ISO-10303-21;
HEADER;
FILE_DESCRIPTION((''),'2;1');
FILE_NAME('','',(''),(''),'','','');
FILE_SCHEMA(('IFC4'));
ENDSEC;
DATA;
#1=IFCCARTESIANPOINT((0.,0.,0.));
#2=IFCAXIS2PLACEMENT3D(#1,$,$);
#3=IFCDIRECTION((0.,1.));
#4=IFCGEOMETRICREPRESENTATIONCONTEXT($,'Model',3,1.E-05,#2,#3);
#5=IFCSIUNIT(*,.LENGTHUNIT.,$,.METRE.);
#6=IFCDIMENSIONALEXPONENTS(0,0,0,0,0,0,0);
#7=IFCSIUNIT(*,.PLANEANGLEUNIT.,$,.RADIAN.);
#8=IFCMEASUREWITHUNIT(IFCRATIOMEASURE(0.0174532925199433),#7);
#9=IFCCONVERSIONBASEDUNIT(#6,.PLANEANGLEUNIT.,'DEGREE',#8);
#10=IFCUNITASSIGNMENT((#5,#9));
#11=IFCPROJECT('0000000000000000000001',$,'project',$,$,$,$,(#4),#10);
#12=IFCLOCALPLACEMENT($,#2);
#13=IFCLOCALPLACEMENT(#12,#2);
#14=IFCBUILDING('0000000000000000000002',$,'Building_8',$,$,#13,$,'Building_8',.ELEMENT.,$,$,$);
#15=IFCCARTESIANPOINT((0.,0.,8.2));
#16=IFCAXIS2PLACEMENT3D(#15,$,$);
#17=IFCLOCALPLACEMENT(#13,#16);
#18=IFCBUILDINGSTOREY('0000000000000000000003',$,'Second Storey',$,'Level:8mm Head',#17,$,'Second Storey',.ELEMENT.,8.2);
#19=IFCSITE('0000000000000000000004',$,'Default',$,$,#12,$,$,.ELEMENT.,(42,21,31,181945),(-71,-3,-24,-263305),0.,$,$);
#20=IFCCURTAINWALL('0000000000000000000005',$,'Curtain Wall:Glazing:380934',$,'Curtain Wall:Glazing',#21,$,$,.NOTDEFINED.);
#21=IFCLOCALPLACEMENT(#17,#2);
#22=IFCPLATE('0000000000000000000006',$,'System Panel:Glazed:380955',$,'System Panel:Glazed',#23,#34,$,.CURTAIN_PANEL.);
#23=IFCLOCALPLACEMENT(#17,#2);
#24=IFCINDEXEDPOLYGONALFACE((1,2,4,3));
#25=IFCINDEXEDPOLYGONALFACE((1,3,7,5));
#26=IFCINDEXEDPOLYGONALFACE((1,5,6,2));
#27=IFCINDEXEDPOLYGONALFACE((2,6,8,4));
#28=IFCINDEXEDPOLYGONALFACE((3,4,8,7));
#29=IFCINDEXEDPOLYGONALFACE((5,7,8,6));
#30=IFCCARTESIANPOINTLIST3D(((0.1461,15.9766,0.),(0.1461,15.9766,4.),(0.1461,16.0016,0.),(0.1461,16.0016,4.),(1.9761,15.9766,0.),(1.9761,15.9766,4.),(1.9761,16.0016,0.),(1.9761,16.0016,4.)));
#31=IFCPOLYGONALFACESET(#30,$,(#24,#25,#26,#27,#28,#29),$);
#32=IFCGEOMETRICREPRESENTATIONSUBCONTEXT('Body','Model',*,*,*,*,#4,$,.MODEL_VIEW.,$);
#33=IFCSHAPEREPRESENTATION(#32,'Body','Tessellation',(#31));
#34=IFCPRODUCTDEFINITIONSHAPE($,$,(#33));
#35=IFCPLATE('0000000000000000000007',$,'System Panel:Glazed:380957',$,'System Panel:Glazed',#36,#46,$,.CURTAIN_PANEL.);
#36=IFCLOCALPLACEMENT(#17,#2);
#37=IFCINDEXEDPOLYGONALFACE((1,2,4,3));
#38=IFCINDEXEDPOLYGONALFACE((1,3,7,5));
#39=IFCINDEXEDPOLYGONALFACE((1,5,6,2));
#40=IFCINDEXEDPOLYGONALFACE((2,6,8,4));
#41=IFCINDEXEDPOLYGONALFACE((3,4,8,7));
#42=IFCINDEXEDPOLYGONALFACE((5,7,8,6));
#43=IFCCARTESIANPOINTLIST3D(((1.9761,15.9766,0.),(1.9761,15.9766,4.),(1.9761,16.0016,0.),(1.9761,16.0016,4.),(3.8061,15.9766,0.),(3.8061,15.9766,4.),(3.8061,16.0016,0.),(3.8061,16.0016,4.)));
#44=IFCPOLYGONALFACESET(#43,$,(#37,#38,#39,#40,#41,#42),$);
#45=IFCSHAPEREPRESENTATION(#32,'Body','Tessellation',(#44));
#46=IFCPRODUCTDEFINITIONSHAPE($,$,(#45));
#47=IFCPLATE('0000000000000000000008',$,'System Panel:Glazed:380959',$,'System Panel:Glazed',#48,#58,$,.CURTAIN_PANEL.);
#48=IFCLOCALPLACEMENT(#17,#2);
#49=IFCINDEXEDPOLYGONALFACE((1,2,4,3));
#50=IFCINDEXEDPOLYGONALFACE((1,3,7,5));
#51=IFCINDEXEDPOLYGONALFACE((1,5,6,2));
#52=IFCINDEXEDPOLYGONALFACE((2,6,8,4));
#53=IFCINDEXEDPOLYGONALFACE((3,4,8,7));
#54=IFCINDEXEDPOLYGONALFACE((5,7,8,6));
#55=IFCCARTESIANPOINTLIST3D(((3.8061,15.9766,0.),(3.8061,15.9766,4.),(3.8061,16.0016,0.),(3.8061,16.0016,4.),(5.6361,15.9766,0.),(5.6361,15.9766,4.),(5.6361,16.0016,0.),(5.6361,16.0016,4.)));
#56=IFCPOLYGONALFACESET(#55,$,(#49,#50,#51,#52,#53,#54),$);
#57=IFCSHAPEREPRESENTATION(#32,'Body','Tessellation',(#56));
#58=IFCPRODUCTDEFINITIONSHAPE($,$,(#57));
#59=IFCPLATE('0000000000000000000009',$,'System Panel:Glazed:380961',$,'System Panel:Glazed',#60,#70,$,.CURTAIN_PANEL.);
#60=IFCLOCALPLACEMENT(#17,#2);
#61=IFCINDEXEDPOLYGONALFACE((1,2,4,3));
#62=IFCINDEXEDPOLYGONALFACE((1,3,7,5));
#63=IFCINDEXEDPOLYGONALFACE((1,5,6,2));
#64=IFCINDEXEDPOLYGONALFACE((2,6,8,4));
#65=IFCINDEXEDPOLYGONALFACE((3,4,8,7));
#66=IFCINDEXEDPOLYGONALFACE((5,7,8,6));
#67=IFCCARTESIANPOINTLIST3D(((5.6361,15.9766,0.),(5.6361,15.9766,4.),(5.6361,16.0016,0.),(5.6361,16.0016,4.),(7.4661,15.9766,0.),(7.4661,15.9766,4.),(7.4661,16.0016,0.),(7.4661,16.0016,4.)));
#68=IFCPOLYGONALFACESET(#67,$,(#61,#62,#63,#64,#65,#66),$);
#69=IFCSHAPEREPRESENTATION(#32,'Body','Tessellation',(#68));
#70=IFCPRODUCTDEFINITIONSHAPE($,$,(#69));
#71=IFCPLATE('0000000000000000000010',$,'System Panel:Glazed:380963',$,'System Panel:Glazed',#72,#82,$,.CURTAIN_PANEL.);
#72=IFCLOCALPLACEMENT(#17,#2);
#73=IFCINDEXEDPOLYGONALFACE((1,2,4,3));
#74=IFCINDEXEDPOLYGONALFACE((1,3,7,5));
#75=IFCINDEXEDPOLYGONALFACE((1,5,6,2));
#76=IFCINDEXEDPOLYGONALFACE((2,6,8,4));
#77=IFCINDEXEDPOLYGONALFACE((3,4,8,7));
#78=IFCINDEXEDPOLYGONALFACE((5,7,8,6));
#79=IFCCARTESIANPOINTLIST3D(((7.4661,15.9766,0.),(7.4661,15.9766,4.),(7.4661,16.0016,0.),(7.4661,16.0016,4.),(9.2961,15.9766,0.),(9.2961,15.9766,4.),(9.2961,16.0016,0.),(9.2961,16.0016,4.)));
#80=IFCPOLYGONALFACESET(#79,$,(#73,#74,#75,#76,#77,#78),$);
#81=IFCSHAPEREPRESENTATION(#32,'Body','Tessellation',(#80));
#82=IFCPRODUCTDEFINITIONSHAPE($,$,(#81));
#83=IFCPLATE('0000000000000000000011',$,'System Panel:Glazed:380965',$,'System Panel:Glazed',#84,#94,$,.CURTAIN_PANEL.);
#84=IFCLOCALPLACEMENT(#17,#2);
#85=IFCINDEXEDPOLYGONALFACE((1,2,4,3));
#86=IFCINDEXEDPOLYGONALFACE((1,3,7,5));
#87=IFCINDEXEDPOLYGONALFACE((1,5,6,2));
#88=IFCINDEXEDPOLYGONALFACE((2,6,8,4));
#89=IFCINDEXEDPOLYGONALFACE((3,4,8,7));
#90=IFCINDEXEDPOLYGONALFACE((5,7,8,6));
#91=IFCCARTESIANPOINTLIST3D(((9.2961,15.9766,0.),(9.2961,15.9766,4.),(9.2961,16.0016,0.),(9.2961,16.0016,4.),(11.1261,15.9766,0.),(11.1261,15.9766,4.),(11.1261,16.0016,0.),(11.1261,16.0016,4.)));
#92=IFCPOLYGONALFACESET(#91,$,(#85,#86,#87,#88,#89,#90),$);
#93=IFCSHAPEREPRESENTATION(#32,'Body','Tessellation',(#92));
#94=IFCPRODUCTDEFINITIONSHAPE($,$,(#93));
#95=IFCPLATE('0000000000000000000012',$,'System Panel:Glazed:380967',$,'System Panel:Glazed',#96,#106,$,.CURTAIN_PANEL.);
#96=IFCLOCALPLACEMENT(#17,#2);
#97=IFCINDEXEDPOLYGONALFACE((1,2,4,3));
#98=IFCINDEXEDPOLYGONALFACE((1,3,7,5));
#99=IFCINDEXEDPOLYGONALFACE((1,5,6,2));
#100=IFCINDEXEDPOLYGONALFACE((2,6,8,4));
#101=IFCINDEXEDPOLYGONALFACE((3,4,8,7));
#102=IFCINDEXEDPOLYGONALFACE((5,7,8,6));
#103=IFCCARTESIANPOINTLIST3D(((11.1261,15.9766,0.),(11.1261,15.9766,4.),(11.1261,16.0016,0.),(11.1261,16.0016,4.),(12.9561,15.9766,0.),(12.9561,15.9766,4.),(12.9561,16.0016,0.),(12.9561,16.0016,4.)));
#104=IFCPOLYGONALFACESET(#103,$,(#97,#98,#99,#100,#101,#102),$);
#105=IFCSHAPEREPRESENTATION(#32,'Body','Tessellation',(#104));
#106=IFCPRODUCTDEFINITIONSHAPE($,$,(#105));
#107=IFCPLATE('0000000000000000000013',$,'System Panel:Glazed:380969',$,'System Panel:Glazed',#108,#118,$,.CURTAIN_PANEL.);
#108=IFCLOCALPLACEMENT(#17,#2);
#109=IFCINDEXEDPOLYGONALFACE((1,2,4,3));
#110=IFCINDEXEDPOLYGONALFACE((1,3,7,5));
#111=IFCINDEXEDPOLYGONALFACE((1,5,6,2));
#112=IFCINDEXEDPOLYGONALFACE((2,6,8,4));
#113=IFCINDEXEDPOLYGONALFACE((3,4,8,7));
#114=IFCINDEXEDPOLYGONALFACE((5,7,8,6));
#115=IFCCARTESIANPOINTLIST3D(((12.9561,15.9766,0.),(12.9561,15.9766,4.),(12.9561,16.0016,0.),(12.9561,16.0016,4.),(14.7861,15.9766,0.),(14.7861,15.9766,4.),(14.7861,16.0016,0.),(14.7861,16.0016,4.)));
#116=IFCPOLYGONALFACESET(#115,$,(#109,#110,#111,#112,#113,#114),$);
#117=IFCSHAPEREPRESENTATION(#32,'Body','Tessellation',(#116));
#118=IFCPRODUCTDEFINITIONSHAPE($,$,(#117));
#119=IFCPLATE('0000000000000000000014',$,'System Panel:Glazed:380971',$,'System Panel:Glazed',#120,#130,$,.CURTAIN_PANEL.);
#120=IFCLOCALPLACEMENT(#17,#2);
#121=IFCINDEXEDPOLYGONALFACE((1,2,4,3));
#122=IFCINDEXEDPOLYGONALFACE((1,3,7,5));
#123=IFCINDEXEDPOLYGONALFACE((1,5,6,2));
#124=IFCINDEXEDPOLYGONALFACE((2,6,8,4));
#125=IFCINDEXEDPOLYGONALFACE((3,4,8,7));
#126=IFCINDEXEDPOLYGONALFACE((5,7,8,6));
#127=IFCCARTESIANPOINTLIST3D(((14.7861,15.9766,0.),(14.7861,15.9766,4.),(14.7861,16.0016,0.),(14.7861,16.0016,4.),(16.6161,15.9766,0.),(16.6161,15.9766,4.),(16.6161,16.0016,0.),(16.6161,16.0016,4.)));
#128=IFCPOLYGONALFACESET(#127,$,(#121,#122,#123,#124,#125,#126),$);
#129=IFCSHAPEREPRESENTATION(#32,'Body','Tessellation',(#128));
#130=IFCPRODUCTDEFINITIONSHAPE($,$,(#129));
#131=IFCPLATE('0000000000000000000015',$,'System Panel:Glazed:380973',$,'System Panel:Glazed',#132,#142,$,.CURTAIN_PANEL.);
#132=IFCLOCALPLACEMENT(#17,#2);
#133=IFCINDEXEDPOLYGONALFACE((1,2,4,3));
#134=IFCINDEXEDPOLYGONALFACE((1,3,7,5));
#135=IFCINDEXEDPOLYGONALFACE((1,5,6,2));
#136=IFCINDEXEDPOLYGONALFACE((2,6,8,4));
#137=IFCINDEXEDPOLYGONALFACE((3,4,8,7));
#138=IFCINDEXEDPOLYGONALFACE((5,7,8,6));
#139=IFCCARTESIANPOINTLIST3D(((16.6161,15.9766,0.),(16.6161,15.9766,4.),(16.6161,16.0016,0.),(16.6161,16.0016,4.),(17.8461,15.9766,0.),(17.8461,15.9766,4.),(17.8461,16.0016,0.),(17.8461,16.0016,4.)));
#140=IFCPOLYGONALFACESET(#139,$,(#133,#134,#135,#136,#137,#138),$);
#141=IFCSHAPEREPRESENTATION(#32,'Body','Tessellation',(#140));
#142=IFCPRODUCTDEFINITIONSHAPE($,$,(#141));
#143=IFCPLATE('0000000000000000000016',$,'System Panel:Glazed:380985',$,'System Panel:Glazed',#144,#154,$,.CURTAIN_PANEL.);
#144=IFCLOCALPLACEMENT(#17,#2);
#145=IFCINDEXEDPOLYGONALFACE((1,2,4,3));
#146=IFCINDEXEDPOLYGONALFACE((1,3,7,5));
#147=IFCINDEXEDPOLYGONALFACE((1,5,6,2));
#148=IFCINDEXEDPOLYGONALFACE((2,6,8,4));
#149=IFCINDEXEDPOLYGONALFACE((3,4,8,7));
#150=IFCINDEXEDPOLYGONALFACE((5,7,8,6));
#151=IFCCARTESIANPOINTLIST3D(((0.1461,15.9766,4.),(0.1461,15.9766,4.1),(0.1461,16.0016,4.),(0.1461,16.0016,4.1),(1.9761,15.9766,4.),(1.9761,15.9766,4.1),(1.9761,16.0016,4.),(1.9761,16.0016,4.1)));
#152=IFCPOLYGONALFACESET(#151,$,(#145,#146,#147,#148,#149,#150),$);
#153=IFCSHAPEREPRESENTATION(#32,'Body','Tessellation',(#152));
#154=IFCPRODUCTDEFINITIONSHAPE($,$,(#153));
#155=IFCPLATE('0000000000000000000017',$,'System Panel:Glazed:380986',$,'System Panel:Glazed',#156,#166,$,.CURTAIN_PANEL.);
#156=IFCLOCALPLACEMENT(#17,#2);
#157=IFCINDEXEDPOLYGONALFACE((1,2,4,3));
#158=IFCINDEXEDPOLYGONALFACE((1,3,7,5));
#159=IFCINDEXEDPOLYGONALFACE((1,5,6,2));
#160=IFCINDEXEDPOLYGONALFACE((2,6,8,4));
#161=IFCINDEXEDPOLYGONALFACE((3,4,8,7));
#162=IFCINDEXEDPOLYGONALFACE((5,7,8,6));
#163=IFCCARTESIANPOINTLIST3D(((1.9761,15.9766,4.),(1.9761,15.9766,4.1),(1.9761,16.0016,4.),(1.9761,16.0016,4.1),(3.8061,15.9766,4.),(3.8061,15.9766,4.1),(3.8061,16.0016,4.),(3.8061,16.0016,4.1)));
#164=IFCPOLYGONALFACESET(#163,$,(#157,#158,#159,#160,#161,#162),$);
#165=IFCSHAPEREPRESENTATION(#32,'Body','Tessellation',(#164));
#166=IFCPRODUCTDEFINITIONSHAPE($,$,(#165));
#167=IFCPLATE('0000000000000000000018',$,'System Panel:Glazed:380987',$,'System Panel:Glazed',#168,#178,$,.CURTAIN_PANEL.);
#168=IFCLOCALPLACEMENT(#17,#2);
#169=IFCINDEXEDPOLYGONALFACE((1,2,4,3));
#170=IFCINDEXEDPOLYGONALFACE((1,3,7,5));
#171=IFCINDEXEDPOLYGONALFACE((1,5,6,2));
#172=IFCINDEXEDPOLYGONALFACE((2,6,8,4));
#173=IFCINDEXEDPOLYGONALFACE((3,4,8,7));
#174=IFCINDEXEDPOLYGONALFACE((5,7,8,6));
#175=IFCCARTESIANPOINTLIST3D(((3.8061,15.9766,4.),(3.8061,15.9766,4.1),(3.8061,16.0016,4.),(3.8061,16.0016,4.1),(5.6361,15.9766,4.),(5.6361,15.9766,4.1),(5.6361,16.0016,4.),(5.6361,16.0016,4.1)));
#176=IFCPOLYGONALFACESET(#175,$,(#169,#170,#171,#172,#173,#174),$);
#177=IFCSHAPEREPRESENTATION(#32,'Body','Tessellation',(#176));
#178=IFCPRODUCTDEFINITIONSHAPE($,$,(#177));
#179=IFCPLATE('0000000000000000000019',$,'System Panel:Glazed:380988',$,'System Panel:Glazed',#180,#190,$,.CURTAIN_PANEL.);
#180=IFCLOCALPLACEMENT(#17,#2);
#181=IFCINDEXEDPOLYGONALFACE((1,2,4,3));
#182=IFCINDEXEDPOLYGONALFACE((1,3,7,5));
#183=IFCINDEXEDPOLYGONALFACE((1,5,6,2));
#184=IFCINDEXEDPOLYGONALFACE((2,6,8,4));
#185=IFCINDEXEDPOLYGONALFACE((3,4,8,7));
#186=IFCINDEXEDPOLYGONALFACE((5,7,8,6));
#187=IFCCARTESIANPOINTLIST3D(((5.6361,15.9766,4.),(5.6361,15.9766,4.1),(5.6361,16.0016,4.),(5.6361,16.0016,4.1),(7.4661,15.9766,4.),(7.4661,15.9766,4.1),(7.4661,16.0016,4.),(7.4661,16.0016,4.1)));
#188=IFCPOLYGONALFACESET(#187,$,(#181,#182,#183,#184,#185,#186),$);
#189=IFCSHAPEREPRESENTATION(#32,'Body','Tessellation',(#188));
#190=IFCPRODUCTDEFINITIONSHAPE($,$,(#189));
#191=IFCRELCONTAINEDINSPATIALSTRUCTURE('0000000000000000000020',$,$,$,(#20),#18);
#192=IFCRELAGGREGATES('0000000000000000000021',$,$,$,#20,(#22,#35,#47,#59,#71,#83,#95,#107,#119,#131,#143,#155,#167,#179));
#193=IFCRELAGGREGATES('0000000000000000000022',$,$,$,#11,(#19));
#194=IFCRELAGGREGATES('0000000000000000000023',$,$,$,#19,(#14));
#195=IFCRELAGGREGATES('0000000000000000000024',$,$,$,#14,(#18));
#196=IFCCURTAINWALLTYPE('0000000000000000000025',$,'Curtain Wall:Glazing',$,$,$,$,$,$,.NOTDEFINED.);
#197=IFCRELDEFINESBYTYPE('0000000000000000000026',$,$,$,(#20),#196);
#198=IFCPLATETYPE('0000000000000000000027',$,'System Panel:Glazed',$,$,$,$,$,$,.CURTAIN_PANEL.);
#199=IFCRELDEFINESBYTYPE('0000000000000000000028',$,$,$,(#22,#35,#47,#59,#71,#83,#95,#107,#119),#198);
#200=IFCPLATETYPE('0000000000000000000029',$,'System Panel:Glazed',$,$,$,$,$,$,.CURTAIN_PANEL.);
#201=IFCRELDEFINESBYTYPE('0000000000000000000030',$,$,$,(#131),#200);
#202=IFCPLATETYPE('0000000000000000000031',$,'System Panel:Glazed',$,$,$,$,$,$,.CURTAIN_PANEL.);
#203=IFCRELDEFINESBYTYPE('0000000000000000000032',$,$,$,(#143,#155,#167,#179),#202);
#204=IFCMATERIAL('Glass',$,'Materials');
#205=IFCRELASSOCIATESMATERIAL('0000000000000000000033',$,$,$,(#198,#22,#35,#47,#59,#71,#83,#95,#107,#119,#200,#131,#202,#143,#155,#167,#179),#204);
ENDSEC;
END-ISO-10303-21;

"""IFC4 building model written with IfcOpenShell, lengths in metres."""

from ifc_helpers import new_model, entity, si_unit, converted_unit, direction, frame, origin, place, context, subcontext, project, spatial, indexed_curve, outline, extrude, source, transform, mapped, material, type_object, type_shapes, element, aggregate, save


model = new_model("IFC4")

# Units and contexts
model_context = context("Model", 3, precision=1e-05, world=origin(), true_north=direction((0.0, 1.0)))
body_context = subcontext(model_context, "Body", "Model", "MODEL_VIEW")
ifc_project = project(units=[si_unit("LENGTHUNIT", "METRE"), converted_unit("PLANEANGLEUNIT", "DEGREE", entity("IfcRatioMeasure", 0.0174532925199433), si_unit("PLANEANGLEUNIT", "RADIAN"), dimensions=[0, 0, 0, 0, 0, 0, 0])], contexts=[model_context])

# Site, building, storey
site_placement = place(None, origin())
site = spatial("IfcSite", under=ifc_project, at=site_placement, Name="Default", CompositionType="ELEMENT", RefLatitude=(42, 21, 31, 181945), RefLongitude=(-71, -3, -24, -263305), RefElevation=0.0)
building_placement = place(site_placement, origin())
building = spatial("IfcBuilding", under=site, at=building_placement, Name="Building_8", LongName="Building_8", CompositionType="ELEMENT")
storey_placement = place(building_placement, frame((0.0, 0.0, 8.2)))
storey = spatial("IfcBuildingStorey", under=building, at=storey_placement, Name="Second Storey", ObjectType="Level:8mm Head", LongName="Second Storey", CompositionType="ELEMENT", Elevation=8.2)

# Curtain wall, plates
curtain_wall_type = type_object("IfcCurtainWallType", Name="Curtain Wall:Glazing", PredefinedType="NOTDEFINED")
curtain_wall_placement = place(storey_placement, frame((0.0, 0.0, -8.2)))
curtain_wall = element("IfcCurtainWall", 1, at=curtain_wall_placement, inside=storey, type_object=curtain_wall_type, Name="Curtain Wall:Glazing:380934", ObjectType="Curtain Wall:Glazing", PredefinedType="NOTDEFINED")
ifc_material_1 = material(Name="Glass", Category="Materials")
plate_type_1 = type_object("IfcPlateType", Name="System Panel:Glazed", PredefinedType="CURTAIN_PANEL", material=ifc_material_1)
shared_shape_1 = source(origin(), body_context, "Body", "SweptSolid", [
    extrude(outline(indexed_curve([(-0.0125, -0.915), (0.0125, -0.915), (0.0125, 0.915), (-0.0125, 0.915), (-0.0125, -0.915)], self_intersect=False)), frame((0.0, 0.037, 0.0), z_axis=(0.0, 0.0, 1.0), x_axis=(0.0, 1.0, 0.0)), (0.0, 0.0, 1.0), 4.0),
])
type_shapes(plate_type_1, [shared_shape_1])
plate_1_placement = place(curtain_wall_placement, frame((1.0611, 15.9521, 8.2)))
plate_1 = element("IfcPlate", 2, at=plate_1_placement, type_object=plate_type_1, material=ifc_material_1, Name="System Panel:Glazed:380955", ObjectType="System Panel:Glazed", PredefinedType="CURTAIN_PANEL", context=body_context, shape_type="MappedRepresentation", body=[
    mapped(shared_shape_1, transform((0.0, 0.0, 0.0), scale=1.0)),
])
plate_2_placement = place(curtain_wall_placement, frame((2.8911, 15.9521, 8.2)))
plate_2 = element("IfcPlate", 3, at=plate_2_placement, type_object=plate_type_1, material=ifc_material_1, Name="System Panel:Glazed:380957", ObjectType="System Panel:Glazed", PredefinedType="CURTAIN_PANEL", context=body_context, shape_type="MappedRepresentation", body=[
    mapped(shared_shape_1, transform((0.0, 0.0, 0.0), scale=1.0)),
])
plate_3_placement = place(curtain_wall_placement, frame((4.7211, 15.9521, 8.2)))
plate_3 = element("IfcPlate", 4, at=plate_3_placement, type_object=plate_type_1, material=ifc_material_1, Name="System Panel:Glazed:380959", ObjectType="System Panel:Glazed", PredefinedType="CURTAIN_PANEL", context=body_context, shape_type="MappedRepresentation", body=[
    mapped(shared_shape_1, transform((0.0, 0.0, 0.0), scale=1.0)),
])
plate_4_placement = place(curtain_wall_placement, frame((6.5511, 15.9521, 8.2)))
plate_4 = element("IfcPlate", 5, at=plate_4_placement, type_object=plate_type_1, material=ifc_material_1, Name="System Panel:Glazed:380961", ObjectType="System Panel:Glazed", PredefinedType="CURTAIN_PANEL", context=body_context, shape_type="MappedRepresentation", body=[
    mapped(shared_shape_1, transform((0.0, 0.0, 0.0), scale=1.0)),
])
plate_5_placement = place(curtain_wall_placement, frame((8.3811, 15.9521, 8.2)))
plate_5 = element("IfcPlate", 6, at=plate_5_placement, type_object=plate_type_1, material=ifc_material_1, Name="System Panel:Glazed:380963", ObjectType="System Panel:Glazed", PredefinedType="CURTAIN_PANEL", context=body_context, shape_type="MappedRepresentation", body=[
    mapped(shared_shape_1, transform((0.0, 0.0, 0.0), scale=1.0)),
])
plate_6_placement = place(curtain_wall_placement, frame((10.2111, 15.9521, 8.2)))
plate_6 = element("IfcPlate", 7, at=plate_6_placement, type_object=plate_type_1, material=ifc_material_1, Name="System Panel:Glazed:380965", ObjectType="System Panel:Glazed", PredefinedType="CURTAIN_PANEL", context=body_context, shape_type="MappedRepresentation", body=[
    mapped(shared_shape_1, transform((0.0, 0.0, 0.0), scale=1.0)),
])
plate_7_placement = place(curtain_wall_placement, frame((12.0411, 15.9521, 8.2)))
plate_7 = element("IfcPlate", 8, at=plate_7_placement, type_object=plate_type_1, material=ifc_material_1, Name="System Panel:Glazed:380967", ObjectType="System Panel:Glazed", PredefinedType="CURTAIN_PANEL", context=body_context, shape_type="MappedRepresentation", body=[
    mapped(shared_shape_1, transform((0.0, 0.0, 0.0), scale=1.0)),
])
plate_8_placement = place(curtain_wall_placement, frame((13.8711, 15.9521, 8.2)))
plate_8 = element("IfcPlate", 9, at=plate_8_placement, type_object=plate_type_1, material=ifc_material_1, Name="System Panel:Glazed:380969", ObjectType="System Panel:Glazed", PredefinedType="CURTAIN_PANEL", context=body_context, shape_type="MappedRepresentation", body=[
    mapped(shared_shape_1, transform((0.0, 0.0, 0.0), scale=1.0)),
])
plate_9_placement = place(curtain_wall_placement, frame((15.7011, 15.9521, 8.2)))
plate_9 = element("IfcPlate", 10, at=plate_9_placement, type_object=plate_type_1, material=ifc_material_1, Name="System Panel:Glazed:380971", ObjectType="System Panel:Glazed", PredefinedType="CURTAIN_PANEL", context=body_context, shape_type="MappedRepresentation", body=[
    mapped(shared_shape_1, transform((0.0, 0.0, 0.0), scale=1.0)),
])
plate_type_2 = type_object("IfcPlateType", Name="System Panel:Glazed", PredefinedType="CURTAIN_PANEL", material=ifc_material_1)
shared_shape_2 = source(origin(), body_context, "Body", "SweptSolid", [
    extrude(outline(indexed_curve([(-0.0125, -0.615), (0.0125, -0.615), (0.0125, 0.615), (-0.0125, 0.615), (-0.0125, -0.615)], self_intersect=False)), frame((0.0, 0.037, 0.0), z_axis=(0.0, 0.0, 1.0), x_axis=(0.0, 1.0, 0.0)), (0.0, 0.0, 1.0), 4.0),
])
type_shapes(plate_type_2, [shared_shape_2])
plate_10_placement = place(curtain_wall_placement, frame((17.2311, 15.9521, 8.2)))
plate_10 = element("IfcPlate", 11, at=plate_10_placement, type_object=plate_type_2, material=ifc_material_1, Name="System Panel:Glazed:380973", ObjectType="System Panel:Glazed", PredefinedType="CURTAIN_PANEL", context=body_context, shape_type="MappedRepresentation", body=[
    mapped(shared_shape_2, transform((0.0, 0.0, 0.0), scale=1.0)),
])
plate_type_3 = type_object("IfcPlateType", Name="System Panel:Glazed", PredefinedType="CURTAIN_PANEL", material=ifc_material_1)
shared_shape_3 = source(origin(), body_context, "Body", "SweptSolid", [
    extrude(outline(indexed_curve([(-0.0125, -0.915), (0.0125, -0.915), (0.0125, 0.915), (-0.0125, 0.915), (-0.0125, -0.915)], self_intersect=False)), frame((0.0, 0.037, 0.0), z_axis=(0.0, 0.0, 1.0), x_axis=(0.0, 1.0, 0.0)), (0.0, 0.0, 1.0), 0.1),
])
type_shapes(plate_type_3, [shared_shape_3])
plate_11_placement = place(curtain_wall_placement, frame((1.0611, 15.9521, 12.2)))
plate_11 = element("IfcPlate", 12, at=plate_11_placement, type_object=plate_type_3, material=ifc_material_1, Name="System Panel:Glazed:380985", ObjectType="System Panel:Glazed", PredefinedType="CURTAIN_PANEL", context=body_context, shape_type="MappedRepresentation", body=[
    mapped(shared_shape_3, transform((0.0, 0.0, 0.0), scale=1.0)),
])
plate_12_placement = place(curtain_wall_placement, frame((2.8911, 15.9521, 12.2)))
plate_12 = element("IfcPlate", 13, at=plate_12_placement, type_object=plate_type_3, material=ifc_material_1, Name="System Panel:Glazed:380986", ObjectType="System Panel:Glazed", PredefinedType="CURTAIN_PANEL", context=body_context, shape_type="MappedRepresentation", body=[
    mapped(shared_shape_3, transform((0.0, 0.0, 0.0), scale=1.0)),
])
plate_13_placement = place(curtain_wall_placement, frame((4.7211, 15.9521, 12.2)))
plate_13 = element("IfcPlate", 14, at=plate_13_placement, type_object=plate_type_3, material=ifc_material_1, Name="System Panel:Glazed:380987", ObjectType="System Panel:Glazed", PredefinedType="CURTAIN_PANEL", context=body_context, shape_type="MappedRepresentation", body=[
    mapped(shared_shape_3, transform((0.0, 0.0, 0.0), scale=1.0)),
])
plate_14_placement = place(curtain_wall_placement, frame((6.5511, 15.9521, 12.2)))
plate_14 = element("IfcPlate", 15, at=plate_14_placement, type_object=plate_type_3, material=ifc_material_1, Name="System Panel:Glazed:380988", ObjectType="System Panel:Glazed", PredefinedType="CURTAIN_PANEL", context=body_context, shape_type="MappedRepresentation", body=[
    mapped(shared_shape_3, transform((0.0, 0.0, 0.0), scale=1.0)),
])
aggregate(curtain_wall, [plate_1, plate_2, plate_3, plate_4, plate_5, plate_6, plate_7, plate_8, plate_9, plate_10, plate_11, plate_12, plate_13, plate_14])

save(model, "model.ifc")
